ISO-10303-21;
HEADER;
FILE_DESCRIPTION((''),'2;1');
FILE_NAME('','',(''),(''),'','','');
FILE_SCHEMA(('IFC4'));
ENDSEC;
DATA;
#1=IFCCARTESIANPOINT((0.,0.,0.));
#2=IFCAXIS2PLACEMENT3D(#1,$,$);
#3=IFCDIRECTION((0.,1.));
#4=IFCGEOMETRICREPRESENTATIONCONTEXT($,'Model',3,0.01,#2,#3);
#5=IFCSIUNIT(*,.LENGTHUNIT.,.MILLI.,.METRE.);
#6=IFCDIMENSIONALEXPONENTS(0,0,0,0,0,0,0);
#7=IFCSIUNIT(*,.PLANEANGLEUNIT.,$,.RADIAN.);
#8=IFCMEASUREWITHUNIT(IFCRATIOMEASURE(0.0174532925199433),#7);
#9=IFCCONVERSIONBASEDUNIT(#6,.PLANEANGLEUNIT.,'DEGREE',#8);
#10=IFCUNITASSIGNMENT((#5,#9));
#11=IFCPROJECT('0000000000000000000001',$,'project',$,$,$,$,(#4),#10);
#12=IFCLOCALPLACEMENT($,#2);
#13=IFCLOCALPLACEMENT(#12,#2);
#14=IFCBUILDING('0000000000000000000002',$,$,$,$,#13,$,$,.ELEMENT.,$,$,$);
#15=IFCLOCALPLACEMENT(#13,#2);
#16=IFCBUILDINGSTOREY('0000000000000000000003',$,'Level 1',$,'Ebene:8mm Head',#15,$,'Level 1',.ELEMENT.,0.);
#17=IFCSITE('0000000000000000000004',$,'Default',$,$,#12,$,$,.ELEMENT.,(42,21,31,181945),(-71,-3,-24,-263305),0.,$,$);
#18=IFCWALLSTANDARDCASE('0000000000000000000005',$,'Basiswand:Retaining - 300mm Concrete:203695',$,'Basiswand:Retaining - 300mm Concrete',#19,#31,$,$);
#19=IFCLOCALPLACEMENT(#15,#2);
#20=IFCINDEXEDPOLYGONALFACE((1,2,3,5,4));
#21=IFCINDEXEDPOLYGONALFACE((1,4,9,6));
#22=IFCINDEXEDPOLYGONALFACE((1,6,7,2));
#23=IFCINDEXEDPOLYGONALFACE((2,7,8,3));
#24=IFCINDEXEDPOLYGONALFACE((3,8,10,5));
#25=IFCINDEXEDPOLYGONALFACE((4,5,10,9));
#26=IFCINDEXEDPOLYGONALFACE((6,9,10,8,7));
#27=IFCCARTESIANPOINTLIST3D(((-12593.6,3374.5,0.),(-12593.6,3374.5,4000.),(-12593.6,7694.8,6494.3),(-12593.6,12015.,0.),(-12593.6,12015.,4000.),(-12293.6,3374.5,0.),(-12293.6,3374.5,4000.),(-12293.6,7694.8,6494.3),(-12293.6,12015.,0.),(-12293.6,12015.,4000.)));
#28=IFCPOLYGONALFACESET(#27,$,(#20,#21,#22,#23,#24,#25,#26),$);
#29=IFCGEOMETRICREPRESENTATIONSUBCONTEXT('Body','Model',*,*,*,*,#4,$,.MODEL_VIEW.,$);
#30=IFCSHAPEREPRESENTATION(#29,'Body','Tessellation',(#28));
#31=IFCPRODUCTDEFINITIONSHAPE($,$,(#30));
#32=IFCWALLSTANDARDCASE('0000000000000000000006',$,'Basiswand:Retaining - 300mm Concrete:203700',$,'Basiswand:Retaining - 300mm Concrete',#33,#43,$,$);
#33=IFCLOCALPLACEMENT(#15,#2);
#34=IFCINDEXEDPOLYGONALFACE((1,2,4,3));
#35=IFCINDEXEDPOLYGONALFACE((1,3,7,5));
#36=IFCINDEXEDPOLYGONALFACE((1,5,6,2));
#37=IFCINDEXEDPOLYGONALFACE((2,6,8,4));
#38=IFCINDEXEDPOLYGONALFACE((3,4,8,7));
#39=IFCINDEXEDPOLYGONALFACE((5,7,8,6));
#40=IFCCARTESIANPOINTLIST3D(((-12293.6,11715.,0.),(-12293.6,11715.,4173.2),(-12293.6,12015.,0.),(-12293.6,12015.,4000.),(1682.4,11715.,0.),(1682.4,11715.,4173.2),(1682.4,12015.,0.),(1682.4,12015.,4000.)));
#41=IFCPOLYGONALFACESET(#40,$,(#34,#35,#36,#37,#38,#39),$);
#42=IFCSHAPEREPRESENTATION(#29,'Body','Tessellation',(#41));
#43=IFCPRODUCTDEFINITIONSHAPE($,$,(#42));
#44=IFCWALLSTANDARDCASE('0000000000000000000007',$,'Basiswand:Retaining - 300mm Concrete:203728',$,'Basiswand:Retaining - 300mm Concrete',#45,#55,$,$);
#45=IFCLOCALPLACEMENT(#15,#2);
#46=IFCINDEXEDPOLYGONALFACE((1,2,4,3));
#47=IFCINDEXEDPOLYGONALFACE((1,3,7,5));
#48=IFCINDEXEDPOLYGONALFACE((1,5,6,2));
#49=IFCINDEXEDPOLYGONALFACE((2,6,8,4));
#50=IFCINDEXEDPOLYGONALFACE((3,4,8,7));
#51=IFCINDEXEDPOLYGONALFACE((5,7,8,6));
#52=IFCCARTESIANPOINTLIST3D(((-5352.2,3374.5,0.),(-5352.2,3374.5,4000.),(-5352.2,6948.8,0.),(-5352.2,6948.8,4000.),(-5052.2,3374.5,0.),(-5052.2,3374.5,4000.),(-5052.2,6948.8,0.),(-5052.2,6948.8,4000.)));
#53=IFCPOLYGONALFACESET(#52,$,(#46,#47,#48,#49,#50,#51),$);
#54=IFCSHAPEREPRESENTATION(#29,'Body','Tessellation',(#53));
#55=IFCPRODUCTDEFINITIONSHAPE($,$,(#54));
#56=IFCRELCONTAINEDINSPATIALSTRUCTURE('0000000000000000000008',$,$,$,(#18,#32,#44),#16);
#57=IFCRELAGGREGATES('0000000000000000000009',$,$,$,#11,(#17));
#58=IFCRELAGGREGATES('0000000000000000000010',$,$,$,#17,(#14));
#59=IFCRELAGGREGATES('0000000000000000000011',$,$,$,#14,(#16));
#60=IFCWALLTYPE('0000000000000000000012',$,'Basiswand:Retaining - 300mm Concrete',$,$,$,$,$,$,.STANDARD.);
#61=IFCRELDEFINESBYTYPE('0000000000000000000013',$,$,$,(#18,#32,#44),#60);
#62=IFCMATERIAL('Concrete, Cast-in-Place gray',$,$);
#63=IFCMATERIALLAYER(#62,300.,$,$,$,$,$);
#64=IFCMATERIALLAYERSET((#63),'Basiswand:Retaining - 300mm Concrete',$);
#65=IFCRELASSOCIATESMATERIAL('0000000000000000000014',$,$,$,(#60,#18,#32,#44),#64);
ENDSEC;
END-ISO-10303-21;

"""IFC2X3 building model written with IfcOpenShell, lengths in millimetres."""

from ifc_helpers import new_model, entity, si_unit, converted_unit, direction, frame, frame_2d, origin, place, context, subcontext, project, spatial, polyline, rectangle, extrude, clip, bounded_halfspace, material, layer, layer_set, layer_usage, type_object, element, save


model = new_model("IFC2X3")

# Units and contexts
model_context = context("Model", 3, precision=0.01, world=origin(), true_north=direction((0.0, 1.0)))
body_context = subcontext(model_context, "Body", "Model", "MODEL_VIEW")
ifc_project = project(units=[si_unit("LENGTHUNIT", "METRE", prefix="MILLI"), converted_unit("PLANEANGLEUNIT", "DEGREE", entity("IfcRatioMeasure", 0.0174532925199433), si_unit("PLANEANGLEUNIT", "RADIAN"), dimensions=[0, 0, 0, 0, 0, 0, 0])], contexts=[model_context])

# Site, building, storey
site_placement = place(None, origin())
site = spatial("IfcSite", under=ifc_project, at=site_placement, Name="Default", CompositionType="ELEMENT", RefLatitude=(42, 21, 31, 181945), RefLongitude=(-71, -3, -24, -263305), RefElevation=0.0)
building_placement = place(site_placement, origin())
building = spatial("IfcBuilding", under=site, at=building_placement, CompositionType="ELEMENT")
storey_placement = place(building_placement, origin())
storey = spatial("IfcBuildingStorey", under=building, at=storey_placement, Name="Level 1", ObjectType="Ebene:8mm Head", LongName="Level 1", CompositionType="ELEMENT", Elevation=0.0)

# Walls
ifc_material_1 = material(Name="Concrete, Cast-in-Place gray")
ifc_layer_1 = layer(ifc_material_1, 300.0)
ifc_layer_set_1 = layer_set([ifc_layer_1], Name="Basiswand:Retaining - 300mm Concrete")
ifc_layer_usage_1 = layer_usage(ifc_layer_set_1, "AXIS2", "NEGATIVE", 150.0)
wall_type = type_object("IfcWallType", Name="Basiswand:Retaining - 300mm Concrete", PredefinedType="STANDARD", material=ifc_layer_set_1)
wall_1_placement = place(storey_placement, frame((-12443.6, 3374.5, 0.0), z_axis=(0.0, 0.0, 1.0), x_axis=(0.0, 1.0, 0.0)))
element("IfcWallStandardCase", 1, at=wall_1_placement, inside=storey, type_object=wall_type, material=ifc_layer_usage_1, Name="Basiswand:Retaining - 300mm Concrete:203695", ObjectType="Basiswand:Retaining - 300mm Concrete", context=body_context, shape_type="Clipping", body=[
    clip(clip(extrude(rectangle(XDim=8640.5, YDim=300.0, at=frame_2d((4320.3, 0.0), x_axis=(-1.0, 0.0))), origin(), (0.0, 0.0, 1.0), 6494.3), bounded_halfspace(frame((0.0, -150.0, 4000.0), z_axis=(-0.5, 0.0, 0.866025), x_axis=(0.0, -1.0, 0.0)), False, frame((0.0, -150.0, 4000.0)), polyline([(0.0, 0.0), (4320.3, 0.0), (4320.3, 300.0), (0.0, 300.0), (0.0, 0.0)]))), bounded_halfspace(frame((4320.3, -150.0, 6494.3), z_axis=(0.5, 0.0, 0.866025), x_axis=(0.0, 1.0, 0.0)), False, frame((4320.3, -150.0, 6494.3)), polyline([(0.0, 0.0), (4020.3, 0.0), (4320.3, 0.0), (4320.3, 300.0), (0.0, 300.0), (0.0, 0.0)]))),
])
ifc_layer_usage_2 = layer_usage(ifc_layer_set_1, "AXIS2", "NEGATIVE", 150.0)
wall_2_placement = place(storey_placement, frame((-12293.6, 11865.0, 0.0)))
element("IfcWallStandardCase", 2, at=wall_2_placement, inside=storey, type_object=wall_type, material=ifc_layer_usage_2, Name="Basiswand:Retaining - 300mm Concrete:203700", ObjectType="Basiswand:Retaining - 300mm Concrete", context=body_context, shape_type="Clipping", body=[
    clip(extrude(rectangle(XDim=13976.0, YDim=300.0, at=frame_2d((6988.0, 0.0), x_axis=(-1.0, 0.0))), origin(), (0.0, 0.0, 1.0), 4173.2), bounded_halfspace(frame((0.0, -150.0, 4173.2), z_axis=(0.0, 0.5, 0.866025), x_axis=(-1.0, 0.0, 0.0)), False, frame((0.0, -150.0, 4173.2)), polyline([(0.0, 0.0), (6941.4, 0.0), (7241.4, 0.0), (13676.0, 0.0), (13976.0, 0.0), (13976.0, 300.0), (0.0, 300.0), (0.0, 0.0)]))),
])
ifc_layer_usage_3 = layer_usage(ifc_layer_set_1, "AXIS2", "NEGATIVE", 150.0)
wall_3_placement = place(storey_placement, frame((-5202.2, 3374.5, 0.0), z_axis=(0.0, 0.0, 1.0), x_axis=(0.0, 1.0, 0.0)))
element("IfcWallStandardCase", 3, at=wall_3_placement, inside=storey, type_object=wall_type, material=ifc_layer_usage_3, Name="Basiswand:Retaining - 300mm Concrete:203728", ObjectType="Basiswand:Retaining - 300mm Concrete", context=body_context, shape_type="SweptSolid", body=[
    extrude(rectangle(XDim=3574.2, YDim=300.0, at=frame_2d((1787.1, 0.0), x_axis=(-1.0, 0.0))), origin(), (0.0, 0.0, 1.0), 4000.0),
])

save(model, "model.ifc")
